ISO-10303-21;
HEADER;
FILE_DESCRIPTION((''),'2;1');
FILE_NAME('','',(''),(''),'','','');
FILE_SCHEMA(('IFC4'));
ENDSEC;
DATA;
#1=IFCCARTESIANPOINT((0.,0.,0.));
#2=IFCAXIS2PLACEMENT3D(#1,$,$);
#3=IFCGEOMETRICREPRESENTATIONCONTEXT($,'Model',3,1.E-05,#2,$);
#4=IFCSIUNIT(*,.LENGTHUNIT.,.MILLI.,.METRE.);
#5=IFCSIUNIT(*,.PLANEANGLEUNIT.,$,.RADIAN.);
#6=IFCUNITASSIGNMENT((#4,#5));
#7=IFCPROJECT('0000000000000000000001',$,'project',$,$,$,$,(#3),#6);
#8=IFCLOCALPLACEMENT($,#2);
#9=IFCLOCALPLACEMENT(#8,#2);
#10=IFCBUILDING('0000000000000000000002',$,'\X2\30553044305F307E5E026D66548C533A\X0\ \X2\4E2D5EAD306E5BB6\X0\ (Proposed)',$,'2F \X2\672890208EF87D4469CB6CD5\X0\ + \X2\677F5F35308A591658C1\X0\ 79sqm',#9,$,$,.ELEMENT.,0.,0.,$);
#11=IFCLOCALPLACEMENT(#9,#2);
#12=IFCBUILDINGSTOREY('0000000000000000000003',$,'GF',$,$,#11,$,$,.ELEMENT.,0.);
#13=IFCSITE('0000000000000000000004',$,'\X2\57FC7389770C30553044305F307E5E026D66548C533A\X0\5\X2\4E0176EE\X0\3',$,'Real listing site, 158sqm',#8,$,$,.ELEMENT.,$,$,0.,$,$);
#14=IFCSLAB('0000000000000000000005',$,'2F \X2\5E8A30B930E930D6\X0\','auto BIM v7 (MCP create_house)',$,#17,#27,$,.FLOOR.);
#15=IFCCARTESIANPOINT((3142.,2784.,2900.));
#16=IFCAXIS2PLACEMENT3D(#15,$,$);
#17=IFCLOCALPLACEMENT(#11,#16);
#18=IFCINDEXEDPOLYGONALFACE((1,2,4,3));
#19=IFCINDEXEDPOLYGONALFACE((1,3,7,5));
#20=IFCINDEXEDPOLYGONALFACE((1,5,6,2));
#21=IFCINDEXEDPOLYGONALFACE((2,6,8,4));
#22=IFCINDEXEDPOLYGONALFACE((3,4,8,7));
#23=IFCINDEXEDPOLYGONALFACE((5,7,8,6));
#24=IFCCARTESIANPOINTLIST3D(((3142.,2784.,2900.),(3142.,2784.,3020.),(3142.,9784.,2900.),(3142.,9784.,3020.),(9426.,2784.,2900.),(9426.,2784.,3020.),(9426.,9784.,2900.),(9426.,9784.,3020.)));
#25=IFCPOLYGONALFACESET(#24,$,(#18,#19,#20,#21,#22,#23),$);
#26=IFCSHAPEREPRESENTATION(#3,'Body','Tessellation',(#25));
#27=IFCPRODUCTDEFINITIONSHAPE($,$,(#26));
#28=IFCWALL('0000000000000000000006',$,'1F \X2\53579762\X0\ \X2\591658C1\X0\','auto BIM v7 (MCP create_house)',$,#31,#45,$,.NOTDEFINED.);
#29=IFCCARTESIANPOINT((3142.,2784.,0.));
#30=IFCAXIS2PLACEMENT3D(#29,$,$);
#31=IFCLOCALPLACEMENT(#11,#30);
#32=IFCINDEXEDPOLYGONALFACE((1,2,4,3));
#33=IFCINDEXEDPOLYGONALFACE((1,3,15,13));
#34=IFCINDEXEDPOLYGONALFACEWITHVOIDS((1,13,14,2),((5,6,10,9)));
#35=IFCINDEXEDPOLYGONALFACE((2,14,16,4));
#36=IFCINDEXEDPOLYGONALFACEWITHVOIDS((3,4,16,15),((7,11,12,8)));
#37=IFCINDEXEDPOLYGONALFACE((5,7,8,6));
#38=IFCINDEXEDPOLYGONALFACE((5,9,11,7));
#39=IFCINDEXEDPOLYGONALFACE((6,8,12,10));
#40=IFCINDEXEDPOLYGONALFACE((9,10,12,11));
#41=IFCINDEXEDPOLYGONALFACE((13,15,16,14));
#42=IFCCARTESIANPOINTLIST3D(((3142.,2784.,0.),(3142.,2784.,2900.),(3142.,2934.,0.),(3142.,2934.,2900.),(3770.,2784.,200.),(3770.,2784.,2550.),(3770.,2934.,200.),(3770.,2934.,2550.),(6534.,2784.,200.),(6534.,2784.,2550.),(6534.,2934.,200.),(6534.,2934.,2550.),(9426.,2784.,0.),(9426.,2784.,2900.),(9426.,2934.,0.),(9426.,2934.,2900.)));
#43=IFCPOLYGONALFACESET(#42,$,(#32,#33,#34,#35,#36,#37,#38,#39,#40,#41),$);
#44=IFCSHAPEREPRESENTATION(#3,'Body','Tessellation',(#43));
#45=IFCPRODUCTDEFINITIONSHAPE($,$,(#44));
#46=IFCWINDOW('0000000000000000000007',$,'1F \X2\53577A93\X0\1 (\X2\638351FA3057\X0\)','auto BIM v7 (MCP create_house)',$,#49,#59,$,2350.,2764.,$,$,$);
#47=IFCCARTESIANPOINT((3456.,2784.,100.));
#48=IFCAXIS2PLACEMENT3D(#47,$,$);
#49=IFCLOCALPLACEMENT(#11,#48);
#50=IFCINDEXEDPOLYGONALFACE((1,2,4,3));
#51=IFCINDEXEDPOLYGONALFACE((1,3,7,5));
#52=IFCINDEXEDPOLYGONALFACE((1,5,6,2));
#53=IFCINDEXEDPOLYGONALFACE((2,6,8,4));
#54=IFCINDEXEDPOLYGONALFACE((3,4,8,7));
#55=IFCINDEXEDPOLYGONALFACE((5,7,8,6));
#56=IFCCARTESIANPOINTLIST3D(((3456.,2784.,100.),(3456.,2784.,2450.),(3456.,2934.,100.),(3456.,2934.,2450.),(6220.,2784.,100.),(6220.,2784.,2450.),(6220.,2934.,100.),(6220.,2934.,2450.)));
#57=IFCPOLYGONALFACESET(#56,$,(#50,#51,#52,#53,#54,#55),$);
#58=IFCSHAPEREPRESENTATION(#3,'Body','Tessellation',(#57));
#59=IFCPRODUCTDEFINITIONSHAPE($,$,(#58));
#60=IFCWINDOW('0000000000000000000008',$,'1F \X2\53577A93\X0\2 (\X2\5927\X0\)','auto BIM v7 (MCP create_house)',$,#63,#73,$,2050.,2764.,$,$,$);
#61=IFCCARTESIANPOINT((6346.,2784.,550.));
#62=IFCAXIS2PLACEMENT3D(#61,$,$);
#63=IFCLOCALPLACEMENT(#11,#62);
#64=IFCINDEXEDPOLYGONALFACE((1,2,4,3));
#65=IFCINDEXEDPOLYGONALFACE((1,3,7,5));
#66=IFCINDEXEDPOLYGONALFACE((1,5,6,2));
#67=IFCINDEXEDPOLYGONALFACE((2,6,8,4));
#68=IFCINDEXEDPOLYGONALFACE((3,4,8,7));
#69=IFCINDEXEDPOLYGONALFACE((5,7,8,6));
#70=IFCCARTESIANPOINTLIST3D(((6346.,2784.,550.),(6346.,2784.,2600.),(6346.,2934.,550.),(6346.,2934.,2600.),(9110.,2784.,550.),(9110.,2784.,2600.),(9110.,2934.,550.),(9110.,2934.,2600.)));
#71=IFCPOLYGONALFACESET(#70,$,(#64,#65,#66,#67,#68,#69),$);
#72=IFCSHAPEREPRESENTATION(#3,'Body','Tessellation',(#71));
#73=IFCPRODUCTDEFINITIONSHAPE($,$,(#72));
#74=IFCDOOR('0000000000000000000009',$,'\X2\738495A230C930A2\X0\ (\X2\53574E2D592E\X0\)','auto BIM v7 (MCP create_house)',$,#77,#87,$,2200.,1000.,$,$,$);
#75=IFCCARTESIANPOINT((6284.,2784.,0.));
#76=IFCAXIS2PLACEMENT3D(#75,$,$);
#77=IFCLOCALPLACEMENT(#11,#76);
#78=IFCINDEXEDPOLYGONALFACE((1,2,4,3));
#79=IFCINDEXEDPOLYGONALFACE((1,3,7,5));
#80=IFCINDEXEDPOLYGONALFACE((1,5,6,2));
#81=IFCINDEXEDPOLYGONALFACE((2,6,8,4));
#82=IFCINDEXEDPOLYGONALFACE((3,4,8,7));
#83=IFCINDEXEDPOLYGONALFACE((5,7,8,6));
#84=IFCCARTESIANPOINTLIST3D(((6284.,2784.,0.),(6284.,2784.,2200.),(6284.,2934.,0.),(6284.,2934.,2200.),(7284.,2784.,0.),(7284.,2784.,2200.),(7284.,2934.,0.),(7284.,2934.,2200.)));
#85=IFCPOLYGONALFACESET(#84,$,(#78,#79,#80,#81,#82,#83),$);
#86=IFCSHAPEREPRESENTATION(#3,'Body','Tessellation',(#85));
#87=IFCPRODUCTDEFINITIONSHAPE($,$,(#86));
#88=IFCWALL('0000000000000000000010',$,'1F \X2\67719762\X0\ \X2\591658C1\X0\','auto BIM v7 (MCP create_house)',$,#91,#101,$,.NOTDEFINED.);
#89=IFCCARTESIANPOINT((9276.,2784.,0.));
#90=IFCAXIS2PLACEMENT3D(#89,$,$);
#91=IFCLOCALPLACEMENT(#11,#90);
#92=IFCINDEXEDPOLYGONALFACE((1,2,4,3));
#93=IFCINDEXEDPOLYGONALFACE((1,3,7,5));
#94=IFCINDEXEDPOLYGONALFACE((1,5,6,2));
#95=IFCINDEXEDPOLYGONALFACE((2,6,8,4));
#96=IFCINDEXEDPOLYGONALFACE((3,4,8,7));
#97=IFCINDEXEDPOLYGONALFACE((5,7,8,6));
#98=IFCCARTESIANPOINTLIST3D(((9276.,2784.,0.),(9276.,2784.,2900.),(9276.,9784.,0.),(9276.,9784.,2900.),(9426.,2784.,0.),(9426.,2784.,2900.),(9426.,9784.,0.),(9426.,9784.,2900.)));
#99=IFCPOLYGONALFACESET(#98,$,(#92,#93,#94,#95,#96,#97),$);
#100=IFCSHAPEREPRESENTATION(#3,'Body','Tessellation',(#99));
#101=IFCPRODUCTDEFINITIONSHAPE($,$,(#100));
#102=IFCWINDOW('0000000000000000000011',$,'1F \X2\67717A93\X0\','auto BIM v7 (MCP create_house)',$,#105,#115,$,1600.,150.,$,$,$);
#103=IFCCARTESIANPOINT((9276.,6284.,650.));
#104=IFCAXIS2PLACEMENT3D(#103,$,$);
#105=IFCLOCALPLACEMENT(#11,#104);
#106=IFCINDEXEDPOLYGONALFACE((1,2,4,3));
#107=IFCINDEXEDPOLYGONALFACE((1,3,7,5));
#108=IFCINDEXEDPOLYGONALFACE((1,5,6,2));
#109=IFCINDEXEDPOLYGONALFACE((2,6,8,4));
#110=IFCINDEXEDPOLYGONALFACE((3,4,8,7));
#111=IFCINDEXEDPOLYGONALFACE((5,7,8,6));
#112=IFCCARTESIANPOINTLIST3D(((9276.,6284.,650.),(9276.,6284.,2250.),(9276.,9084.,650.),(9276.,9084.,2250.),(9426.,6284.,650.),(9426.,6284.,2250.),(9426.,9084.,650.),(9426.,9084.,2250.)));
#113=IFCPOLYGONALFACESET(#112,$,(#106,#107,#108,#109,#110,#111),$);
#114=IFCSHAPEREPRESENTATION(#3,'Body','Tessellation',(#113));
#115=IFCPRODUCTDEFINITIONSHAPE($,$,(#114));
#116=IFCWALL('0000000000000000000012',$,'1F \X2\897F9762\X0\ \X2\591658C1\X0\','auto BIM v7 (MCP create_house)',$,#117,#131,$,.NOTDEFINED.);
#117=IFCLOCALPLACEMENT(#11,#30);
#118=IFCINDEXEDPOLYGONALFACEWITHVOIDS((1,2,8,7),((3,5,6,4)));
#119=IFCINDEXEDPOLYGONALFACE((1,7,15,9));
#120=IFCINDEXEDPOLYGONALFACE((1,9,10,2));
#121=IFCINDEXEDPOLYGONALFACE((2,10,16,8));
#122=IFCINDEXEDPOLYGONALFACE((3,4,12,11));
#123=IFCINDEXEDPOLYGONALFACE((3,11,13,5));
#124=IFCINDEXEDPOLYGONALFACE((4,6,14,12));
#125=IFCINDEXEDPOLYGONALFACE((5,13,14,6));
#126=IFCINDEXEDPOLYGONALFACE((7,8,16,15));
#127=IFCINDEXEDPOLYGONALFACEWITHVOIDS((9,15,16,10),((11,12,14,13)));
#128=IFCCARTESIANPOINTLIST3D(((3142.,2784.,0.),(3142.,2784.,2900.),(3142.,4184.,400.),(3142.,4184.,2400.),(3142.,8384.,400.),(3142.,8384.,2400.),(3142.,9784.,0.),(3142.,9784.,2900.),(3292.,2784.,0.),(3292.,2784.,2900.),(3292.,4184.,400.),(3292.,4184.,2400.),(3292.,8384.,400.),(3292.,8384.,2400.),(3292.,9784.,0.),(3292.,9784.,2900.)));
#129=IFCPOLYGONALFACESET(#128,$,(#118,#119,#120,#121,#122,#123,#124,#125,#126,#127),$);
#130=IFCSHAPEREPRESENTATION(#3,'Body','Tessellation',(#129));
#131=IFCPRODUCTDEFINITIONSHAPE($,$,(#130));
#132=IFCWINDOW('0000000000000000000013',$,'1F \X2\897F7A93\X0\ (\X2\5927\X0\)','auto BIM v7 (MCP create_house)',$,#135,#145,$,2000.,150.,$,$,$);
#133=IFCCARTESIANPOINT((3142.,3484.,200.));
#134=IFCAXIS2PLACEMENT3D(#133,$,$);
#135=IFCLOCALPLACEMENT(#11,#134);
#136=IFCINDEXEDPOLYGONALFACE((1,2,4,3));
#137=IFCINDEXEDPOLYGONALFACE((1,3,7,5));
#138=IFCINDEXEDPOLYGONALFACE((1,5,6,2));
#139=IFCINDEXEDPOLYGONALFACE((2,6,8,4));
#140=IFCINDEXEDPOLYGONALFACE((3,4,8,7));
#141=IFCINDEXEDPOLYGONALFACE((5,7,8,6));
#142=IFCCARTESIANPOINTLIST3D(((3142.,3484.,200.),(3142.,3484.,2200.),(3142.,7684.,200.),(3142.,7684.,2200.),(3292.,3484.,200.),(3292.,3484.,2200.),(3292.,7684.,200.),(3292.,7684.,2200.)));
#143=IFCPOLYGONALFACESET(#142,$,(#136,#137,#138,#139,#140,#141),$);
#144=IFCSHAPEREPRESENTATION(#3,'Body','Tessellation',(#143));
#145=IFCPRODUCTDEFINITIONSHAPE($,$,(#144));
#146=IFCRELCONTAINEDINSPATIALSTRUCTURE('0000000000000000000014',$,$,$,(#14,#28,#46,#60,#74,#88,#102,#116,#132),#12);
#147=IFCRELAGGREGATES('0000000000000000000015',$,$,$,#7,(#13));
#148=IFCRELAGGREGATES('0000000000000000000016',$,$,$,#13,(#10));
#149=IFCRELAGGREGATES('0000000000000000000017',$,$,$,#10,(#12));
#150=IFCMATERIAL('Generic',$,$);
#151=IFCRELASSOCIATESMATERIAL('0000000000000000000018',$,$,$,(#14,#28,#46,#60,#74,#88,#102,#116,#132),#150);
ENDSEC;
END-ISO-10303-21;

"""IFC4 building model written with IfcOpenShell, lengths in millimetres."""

from ifc_helpers import new_model, si_unit, frame, frame_2d, origin, place, context, project, spatial, rectangle, extrude, material, element, fill, save


model = new_model("IFC4")

# Units and contexts
model_context = context("Model", 3, precision=1e-05, world=origin())
ifc_project = project(units=[si_unit("LENGTHUNIT", "METRE", prefix="MILLI"), si_unit("PLANEANGLEUNIT", "RADIAN")], contexts=[model_context])

# Site, building, storey
site_placement = place(None, origin())
site = spatial("IfcSite", under=ifc_project, at=site_placement, Name="埼玉県さいたま市浦和区5丁目3", ObjectType="Real listing site, 158sqm", CompositionType="ELEMENT", RefElevation=0.0)
building_placement = place(site_placement, origin())
building = spatial("IfcBuilding", under=site, at=building_placement, Name="さいたま市浦和区 中庭の家 (Proposed)", ObjectType="2F 木造軸組構法 + 板張り外壁 79sqm", CompositionType="ELEMENT", ElevationOfRefHeight=0.0, ElevationOfTerrain=0.0)
storey_placement = place(building_placement, origin())
storey = spatial("IfcBuildingStorey", under=building, at=storey_placement, Name="GF", CompositionType="ELEMENT", Elevation=0.0)

# Slab
ifc_material = material(Name="Generic")
slab_1_placement = place(storey_placement, frame((3142.0, 2784.0, 2900.0)))
element("IfcSlab", 1, at=slab_1_placement, inside=storey, material=ifc_material, Name="2F 床スラブ", Description="auto BIM v7 (MCP create_house)", PredefinedType="FLOOR", context=model_context, shape_type="SweptSolid", body=[
    extrude(rectangle(XDim=6284.0, YDim=7000.0, at=frame_2d((3142.0, 3500.0))), frame((3142.0, 2784.0, 2900.0)), (0.0, 0.0, 1.0), 120.0),
])

# Wall, openings, windows, door
wall_1_placement = place(storey_placement, frame((3142.0, 2784.0, 0.0)))
wall_1 = element("IfcWall", 2, at=wall_1_placement, inside=storey, material=ifc_material, Name="1F 南面 外壁", Description="auto BIM v7 (MCP create_house)", PredefinedType="NOTDEFINED", context=model_context, shape_type="SweptSolid", body=[
    extrude(rectangle(XDim=6284.0, YDim=150.0, at=frame_2d((3142.0, 75.0))), frame((3142.0, 2784.0, 0.0)), (0.0, 0.0, 1.0), 2900.0),
])
opening_1_placement = place(storey_placement, frame((3456.0, 2784.0, 100.0)))
opening_1 = element("IfcOpeningElement", 3, at=opening_1_placement, cuts=wall_1, PredefinedType="NOTDEFINED", context=model_context, shape_type="SweptSolid", body=[
    extrude(rectangle(XDim=2764.0, YDim=150.0, at=frame_2d((1382.0, 75.0))), frame((3456.0, 2784.0, 100.0)), (0.0, 0.0, 1.0), 2350.0),
])
opening_2_placement = place(storey_placement, frame((6346.0, 2784.0, 550.0)))
opening_2 = element("IfcOpeningElement", 4, at=opening_2_placement, cuts=wall_1, PredefinedType="NOTDEFINED", context=model_context, shape_type="SweptSolid", body=[
    extrude(rectangle(XDim=2764.0, YDim=150.0, at=frame_2d((1382.0, 75.0))), frame((6346.0, 2784.0, 550.0)), (0.0, 0.0, 1.0), 2050.0),
])
opening_3_placement = place(storey_placement, frame((6284.0, 2784.0, 0.0)))
opening_3 = element("IfcOpeningElement", 5, at=opening_3_placement, cuts=wall_1, PredefinedType="NOTDEFINED", context=model_context, shape_type="SweptSolid", body=[
    extrude(rectangle(XDim=1000.0, YDim=150.0, at=frame_2d((500.0, 75.0))), frame((6284.0, 2784.0, 0.0)), (0.0, 0.0, 1.0), 2200.0),
])
window_1_placement = place(storey_placement, frame((3456.0, 2784.0, 100.0)))
window_1 = element("IfcWindow", 6, at=window_1_placement, inside=storey, material=ifc_material, Name="1F 南窓1 (掃出し)", Description="auto BIM v7 (MCP create_house)", OverallHeight=2350.0, OverallWidth=2764.0, context=model_context, shape_type="SweptSolid", body=[
    extrude(rectangle(XDim=2764.0, YDim=150.0, at=frame_2d((1382.0, 75.0))), frame((3456.0, 2784.0, 100.0)), (0.0, 0.0, 1.0), 2350.0),
])
fill(opening_1, window_1)
window_2_placement = place(storey_placement, frame((6346.0, 2784.0, 550.0)))
window_2 = element("IfcWindow", 7, at=window_2_placement, inside=storey, material=ifc_material, Name="1F 南窓2 (大)", Description="auto BIM v7 (MCP create_house)", OverallHeight=2050.0, OverallWidth=2764.0, context=model_context, shape_type="SweptSolid", body=[
    extrude(rectangle(XDim=2764.0, YDim=150.0, at=frame_2d((1382.0, 75.0))), frame((6346.0, 2784.0, 550.0)), (0.0, 0.0, 1.0), 2050.0),
])
fill(opening_2, window_2)
door_placement = place(storey_placement, frame((6284.0, 2784.0, 0.0)))
door = element("IfcDoor", 8, at=door_placement, inside=storey, material=ifc_material, Name="玄関ドア (南中央)", Description="auto BIM v7 (MCP create_house)", OverallHeight=2200.0, OverallWidth=1000.0, context=model_context, shape_type="SweptSolid", body=[
    extrude(rectangle(XDim=1000.0, YDim=150.0, at=frame_2d((500.0, 75.0))), frame((6284.0, 2784.0, 0.0)), (0.0, 0.0, 1.0), 2200.0),
])
fill(opening_3, door)

# Walls, openings, windows
wall_2_placement = place(storey_placement, frame((9276.0, 2784.0, 0.0)))
wall_2 = element("IfcWall", 9, at=wall_2_placement, inside=storey, material=ifc_material, Name="1F 東面 外壁", Description="auto BIM v7 (MCP create_house)", PredefinedType="NOTDEFINED", context=model_context, shape_type="SweptSolid", body=[
    extrude(rectangle(XDim=150.0, YDim=7000.0, at=frame_2d((75.0, 3500.0))), frame((9276.0, 2784.0, 0.0)), (0.0, 0.0, 1.0), 2900.0),
])
opening_4_placement = place(storey_placement, frame((9276.0, 6284.0, 650.0)))
opening_4 = element("IfcOpeningElement", 10, at=opening_4_placement, cuts=wall_2, PredefinedType="NOTDEFINED", context=model_context, shape_type="SweptSolid", body=[
    extrude(rectangle(XDim=150.0, YDim=2800.0, at=frame_2d((75.0, 1400.0))), frame((9276.0, 6284.0, 650.0)), (0.0, 0.0, 1.0), 1600.0),
])
window_3_placement = place(storey_placement, frame((9276.0, 6284.0, 650.0)))
window_3 = element("IfcWindow", 11, at=window_3_placement, inside=storey, material=ifc_material, Name="1F 東窓", Description="auto BIM v7 (MCP create_house)", OverallHeight=1600.0, OverallWidth=150.0, context=model_context, shape_type="SweptSolid", body=[
    extrude(rectangle(XDim=150.0, YDim=2800.0, at=frame_2d((75.0, 1400.0))), frame((9276.0, 6284.0, 650.0)), (0.0, 0.0, 1.0), 1600.0),
])
fill(opening_4, window_3)
wall_3_placement = place(storey_placement, frame((3142.0, 2784.0, 0.0)))
wall_3 = element("IfcWall", 12, at=wall_3_placement, inside=storey, material=ifc_material, Name="1F 西面 外壁", Description="auto BIM v7 (MCP create_house)", PredefinedType="NOTDEFINED", context=model_context, shape_type="SweptSolid", body=[
    extrude(rectangle(XDim=150.0, YDim=7000.0, at=frame_2d((75.0, 3500.0))), frame((3142.0, 2784.0, 0.0)), (0.0, 0.0, 1.0), 2900.0),
])
opening_5_placement = place(storey_placement, frame((3142.0, 3484.0, 200.0)))
opening_5 = element("IfcOpeningElement", 13, at=opening_5_placement, cuts=wall_3, PredefinedType="NOTDEFINED", context=model_context, shape_type="SweptSolid", body=[
    extrude(rectangle(XDim=150.0, YDim=4200.0, at=frame_2d((75.0, 2100.0))), frame((3142.0, 3484.0, 200.0)), (0.0, 0.0, 1.0), 2000.0),
])
window_4_placement = place(storey_placement, frame((3142.0, 3484.0, 200.0)))
window_4 = element("IfcWindow", 14, at=window_4_placement, inside=storey, material=ifc_material, Name="1F 西窓 (大)", Description="auto BIM v7 (MCP create_house)", OverallHeight=2000.0, OverallWidth=150.0, context=model_context, shape_type="SweptSolid", body=[
    extrude(rectangle(XDim=150.0, YDim=4200.0, at=frame_2d((75.0, 2100.0))), frame((3142.0, 3484.0, 200.0)), (0.0, 0.0, 1.0), 2000.0),
])
fill(opening_5, window_4)

save(model, "model.ifc")
